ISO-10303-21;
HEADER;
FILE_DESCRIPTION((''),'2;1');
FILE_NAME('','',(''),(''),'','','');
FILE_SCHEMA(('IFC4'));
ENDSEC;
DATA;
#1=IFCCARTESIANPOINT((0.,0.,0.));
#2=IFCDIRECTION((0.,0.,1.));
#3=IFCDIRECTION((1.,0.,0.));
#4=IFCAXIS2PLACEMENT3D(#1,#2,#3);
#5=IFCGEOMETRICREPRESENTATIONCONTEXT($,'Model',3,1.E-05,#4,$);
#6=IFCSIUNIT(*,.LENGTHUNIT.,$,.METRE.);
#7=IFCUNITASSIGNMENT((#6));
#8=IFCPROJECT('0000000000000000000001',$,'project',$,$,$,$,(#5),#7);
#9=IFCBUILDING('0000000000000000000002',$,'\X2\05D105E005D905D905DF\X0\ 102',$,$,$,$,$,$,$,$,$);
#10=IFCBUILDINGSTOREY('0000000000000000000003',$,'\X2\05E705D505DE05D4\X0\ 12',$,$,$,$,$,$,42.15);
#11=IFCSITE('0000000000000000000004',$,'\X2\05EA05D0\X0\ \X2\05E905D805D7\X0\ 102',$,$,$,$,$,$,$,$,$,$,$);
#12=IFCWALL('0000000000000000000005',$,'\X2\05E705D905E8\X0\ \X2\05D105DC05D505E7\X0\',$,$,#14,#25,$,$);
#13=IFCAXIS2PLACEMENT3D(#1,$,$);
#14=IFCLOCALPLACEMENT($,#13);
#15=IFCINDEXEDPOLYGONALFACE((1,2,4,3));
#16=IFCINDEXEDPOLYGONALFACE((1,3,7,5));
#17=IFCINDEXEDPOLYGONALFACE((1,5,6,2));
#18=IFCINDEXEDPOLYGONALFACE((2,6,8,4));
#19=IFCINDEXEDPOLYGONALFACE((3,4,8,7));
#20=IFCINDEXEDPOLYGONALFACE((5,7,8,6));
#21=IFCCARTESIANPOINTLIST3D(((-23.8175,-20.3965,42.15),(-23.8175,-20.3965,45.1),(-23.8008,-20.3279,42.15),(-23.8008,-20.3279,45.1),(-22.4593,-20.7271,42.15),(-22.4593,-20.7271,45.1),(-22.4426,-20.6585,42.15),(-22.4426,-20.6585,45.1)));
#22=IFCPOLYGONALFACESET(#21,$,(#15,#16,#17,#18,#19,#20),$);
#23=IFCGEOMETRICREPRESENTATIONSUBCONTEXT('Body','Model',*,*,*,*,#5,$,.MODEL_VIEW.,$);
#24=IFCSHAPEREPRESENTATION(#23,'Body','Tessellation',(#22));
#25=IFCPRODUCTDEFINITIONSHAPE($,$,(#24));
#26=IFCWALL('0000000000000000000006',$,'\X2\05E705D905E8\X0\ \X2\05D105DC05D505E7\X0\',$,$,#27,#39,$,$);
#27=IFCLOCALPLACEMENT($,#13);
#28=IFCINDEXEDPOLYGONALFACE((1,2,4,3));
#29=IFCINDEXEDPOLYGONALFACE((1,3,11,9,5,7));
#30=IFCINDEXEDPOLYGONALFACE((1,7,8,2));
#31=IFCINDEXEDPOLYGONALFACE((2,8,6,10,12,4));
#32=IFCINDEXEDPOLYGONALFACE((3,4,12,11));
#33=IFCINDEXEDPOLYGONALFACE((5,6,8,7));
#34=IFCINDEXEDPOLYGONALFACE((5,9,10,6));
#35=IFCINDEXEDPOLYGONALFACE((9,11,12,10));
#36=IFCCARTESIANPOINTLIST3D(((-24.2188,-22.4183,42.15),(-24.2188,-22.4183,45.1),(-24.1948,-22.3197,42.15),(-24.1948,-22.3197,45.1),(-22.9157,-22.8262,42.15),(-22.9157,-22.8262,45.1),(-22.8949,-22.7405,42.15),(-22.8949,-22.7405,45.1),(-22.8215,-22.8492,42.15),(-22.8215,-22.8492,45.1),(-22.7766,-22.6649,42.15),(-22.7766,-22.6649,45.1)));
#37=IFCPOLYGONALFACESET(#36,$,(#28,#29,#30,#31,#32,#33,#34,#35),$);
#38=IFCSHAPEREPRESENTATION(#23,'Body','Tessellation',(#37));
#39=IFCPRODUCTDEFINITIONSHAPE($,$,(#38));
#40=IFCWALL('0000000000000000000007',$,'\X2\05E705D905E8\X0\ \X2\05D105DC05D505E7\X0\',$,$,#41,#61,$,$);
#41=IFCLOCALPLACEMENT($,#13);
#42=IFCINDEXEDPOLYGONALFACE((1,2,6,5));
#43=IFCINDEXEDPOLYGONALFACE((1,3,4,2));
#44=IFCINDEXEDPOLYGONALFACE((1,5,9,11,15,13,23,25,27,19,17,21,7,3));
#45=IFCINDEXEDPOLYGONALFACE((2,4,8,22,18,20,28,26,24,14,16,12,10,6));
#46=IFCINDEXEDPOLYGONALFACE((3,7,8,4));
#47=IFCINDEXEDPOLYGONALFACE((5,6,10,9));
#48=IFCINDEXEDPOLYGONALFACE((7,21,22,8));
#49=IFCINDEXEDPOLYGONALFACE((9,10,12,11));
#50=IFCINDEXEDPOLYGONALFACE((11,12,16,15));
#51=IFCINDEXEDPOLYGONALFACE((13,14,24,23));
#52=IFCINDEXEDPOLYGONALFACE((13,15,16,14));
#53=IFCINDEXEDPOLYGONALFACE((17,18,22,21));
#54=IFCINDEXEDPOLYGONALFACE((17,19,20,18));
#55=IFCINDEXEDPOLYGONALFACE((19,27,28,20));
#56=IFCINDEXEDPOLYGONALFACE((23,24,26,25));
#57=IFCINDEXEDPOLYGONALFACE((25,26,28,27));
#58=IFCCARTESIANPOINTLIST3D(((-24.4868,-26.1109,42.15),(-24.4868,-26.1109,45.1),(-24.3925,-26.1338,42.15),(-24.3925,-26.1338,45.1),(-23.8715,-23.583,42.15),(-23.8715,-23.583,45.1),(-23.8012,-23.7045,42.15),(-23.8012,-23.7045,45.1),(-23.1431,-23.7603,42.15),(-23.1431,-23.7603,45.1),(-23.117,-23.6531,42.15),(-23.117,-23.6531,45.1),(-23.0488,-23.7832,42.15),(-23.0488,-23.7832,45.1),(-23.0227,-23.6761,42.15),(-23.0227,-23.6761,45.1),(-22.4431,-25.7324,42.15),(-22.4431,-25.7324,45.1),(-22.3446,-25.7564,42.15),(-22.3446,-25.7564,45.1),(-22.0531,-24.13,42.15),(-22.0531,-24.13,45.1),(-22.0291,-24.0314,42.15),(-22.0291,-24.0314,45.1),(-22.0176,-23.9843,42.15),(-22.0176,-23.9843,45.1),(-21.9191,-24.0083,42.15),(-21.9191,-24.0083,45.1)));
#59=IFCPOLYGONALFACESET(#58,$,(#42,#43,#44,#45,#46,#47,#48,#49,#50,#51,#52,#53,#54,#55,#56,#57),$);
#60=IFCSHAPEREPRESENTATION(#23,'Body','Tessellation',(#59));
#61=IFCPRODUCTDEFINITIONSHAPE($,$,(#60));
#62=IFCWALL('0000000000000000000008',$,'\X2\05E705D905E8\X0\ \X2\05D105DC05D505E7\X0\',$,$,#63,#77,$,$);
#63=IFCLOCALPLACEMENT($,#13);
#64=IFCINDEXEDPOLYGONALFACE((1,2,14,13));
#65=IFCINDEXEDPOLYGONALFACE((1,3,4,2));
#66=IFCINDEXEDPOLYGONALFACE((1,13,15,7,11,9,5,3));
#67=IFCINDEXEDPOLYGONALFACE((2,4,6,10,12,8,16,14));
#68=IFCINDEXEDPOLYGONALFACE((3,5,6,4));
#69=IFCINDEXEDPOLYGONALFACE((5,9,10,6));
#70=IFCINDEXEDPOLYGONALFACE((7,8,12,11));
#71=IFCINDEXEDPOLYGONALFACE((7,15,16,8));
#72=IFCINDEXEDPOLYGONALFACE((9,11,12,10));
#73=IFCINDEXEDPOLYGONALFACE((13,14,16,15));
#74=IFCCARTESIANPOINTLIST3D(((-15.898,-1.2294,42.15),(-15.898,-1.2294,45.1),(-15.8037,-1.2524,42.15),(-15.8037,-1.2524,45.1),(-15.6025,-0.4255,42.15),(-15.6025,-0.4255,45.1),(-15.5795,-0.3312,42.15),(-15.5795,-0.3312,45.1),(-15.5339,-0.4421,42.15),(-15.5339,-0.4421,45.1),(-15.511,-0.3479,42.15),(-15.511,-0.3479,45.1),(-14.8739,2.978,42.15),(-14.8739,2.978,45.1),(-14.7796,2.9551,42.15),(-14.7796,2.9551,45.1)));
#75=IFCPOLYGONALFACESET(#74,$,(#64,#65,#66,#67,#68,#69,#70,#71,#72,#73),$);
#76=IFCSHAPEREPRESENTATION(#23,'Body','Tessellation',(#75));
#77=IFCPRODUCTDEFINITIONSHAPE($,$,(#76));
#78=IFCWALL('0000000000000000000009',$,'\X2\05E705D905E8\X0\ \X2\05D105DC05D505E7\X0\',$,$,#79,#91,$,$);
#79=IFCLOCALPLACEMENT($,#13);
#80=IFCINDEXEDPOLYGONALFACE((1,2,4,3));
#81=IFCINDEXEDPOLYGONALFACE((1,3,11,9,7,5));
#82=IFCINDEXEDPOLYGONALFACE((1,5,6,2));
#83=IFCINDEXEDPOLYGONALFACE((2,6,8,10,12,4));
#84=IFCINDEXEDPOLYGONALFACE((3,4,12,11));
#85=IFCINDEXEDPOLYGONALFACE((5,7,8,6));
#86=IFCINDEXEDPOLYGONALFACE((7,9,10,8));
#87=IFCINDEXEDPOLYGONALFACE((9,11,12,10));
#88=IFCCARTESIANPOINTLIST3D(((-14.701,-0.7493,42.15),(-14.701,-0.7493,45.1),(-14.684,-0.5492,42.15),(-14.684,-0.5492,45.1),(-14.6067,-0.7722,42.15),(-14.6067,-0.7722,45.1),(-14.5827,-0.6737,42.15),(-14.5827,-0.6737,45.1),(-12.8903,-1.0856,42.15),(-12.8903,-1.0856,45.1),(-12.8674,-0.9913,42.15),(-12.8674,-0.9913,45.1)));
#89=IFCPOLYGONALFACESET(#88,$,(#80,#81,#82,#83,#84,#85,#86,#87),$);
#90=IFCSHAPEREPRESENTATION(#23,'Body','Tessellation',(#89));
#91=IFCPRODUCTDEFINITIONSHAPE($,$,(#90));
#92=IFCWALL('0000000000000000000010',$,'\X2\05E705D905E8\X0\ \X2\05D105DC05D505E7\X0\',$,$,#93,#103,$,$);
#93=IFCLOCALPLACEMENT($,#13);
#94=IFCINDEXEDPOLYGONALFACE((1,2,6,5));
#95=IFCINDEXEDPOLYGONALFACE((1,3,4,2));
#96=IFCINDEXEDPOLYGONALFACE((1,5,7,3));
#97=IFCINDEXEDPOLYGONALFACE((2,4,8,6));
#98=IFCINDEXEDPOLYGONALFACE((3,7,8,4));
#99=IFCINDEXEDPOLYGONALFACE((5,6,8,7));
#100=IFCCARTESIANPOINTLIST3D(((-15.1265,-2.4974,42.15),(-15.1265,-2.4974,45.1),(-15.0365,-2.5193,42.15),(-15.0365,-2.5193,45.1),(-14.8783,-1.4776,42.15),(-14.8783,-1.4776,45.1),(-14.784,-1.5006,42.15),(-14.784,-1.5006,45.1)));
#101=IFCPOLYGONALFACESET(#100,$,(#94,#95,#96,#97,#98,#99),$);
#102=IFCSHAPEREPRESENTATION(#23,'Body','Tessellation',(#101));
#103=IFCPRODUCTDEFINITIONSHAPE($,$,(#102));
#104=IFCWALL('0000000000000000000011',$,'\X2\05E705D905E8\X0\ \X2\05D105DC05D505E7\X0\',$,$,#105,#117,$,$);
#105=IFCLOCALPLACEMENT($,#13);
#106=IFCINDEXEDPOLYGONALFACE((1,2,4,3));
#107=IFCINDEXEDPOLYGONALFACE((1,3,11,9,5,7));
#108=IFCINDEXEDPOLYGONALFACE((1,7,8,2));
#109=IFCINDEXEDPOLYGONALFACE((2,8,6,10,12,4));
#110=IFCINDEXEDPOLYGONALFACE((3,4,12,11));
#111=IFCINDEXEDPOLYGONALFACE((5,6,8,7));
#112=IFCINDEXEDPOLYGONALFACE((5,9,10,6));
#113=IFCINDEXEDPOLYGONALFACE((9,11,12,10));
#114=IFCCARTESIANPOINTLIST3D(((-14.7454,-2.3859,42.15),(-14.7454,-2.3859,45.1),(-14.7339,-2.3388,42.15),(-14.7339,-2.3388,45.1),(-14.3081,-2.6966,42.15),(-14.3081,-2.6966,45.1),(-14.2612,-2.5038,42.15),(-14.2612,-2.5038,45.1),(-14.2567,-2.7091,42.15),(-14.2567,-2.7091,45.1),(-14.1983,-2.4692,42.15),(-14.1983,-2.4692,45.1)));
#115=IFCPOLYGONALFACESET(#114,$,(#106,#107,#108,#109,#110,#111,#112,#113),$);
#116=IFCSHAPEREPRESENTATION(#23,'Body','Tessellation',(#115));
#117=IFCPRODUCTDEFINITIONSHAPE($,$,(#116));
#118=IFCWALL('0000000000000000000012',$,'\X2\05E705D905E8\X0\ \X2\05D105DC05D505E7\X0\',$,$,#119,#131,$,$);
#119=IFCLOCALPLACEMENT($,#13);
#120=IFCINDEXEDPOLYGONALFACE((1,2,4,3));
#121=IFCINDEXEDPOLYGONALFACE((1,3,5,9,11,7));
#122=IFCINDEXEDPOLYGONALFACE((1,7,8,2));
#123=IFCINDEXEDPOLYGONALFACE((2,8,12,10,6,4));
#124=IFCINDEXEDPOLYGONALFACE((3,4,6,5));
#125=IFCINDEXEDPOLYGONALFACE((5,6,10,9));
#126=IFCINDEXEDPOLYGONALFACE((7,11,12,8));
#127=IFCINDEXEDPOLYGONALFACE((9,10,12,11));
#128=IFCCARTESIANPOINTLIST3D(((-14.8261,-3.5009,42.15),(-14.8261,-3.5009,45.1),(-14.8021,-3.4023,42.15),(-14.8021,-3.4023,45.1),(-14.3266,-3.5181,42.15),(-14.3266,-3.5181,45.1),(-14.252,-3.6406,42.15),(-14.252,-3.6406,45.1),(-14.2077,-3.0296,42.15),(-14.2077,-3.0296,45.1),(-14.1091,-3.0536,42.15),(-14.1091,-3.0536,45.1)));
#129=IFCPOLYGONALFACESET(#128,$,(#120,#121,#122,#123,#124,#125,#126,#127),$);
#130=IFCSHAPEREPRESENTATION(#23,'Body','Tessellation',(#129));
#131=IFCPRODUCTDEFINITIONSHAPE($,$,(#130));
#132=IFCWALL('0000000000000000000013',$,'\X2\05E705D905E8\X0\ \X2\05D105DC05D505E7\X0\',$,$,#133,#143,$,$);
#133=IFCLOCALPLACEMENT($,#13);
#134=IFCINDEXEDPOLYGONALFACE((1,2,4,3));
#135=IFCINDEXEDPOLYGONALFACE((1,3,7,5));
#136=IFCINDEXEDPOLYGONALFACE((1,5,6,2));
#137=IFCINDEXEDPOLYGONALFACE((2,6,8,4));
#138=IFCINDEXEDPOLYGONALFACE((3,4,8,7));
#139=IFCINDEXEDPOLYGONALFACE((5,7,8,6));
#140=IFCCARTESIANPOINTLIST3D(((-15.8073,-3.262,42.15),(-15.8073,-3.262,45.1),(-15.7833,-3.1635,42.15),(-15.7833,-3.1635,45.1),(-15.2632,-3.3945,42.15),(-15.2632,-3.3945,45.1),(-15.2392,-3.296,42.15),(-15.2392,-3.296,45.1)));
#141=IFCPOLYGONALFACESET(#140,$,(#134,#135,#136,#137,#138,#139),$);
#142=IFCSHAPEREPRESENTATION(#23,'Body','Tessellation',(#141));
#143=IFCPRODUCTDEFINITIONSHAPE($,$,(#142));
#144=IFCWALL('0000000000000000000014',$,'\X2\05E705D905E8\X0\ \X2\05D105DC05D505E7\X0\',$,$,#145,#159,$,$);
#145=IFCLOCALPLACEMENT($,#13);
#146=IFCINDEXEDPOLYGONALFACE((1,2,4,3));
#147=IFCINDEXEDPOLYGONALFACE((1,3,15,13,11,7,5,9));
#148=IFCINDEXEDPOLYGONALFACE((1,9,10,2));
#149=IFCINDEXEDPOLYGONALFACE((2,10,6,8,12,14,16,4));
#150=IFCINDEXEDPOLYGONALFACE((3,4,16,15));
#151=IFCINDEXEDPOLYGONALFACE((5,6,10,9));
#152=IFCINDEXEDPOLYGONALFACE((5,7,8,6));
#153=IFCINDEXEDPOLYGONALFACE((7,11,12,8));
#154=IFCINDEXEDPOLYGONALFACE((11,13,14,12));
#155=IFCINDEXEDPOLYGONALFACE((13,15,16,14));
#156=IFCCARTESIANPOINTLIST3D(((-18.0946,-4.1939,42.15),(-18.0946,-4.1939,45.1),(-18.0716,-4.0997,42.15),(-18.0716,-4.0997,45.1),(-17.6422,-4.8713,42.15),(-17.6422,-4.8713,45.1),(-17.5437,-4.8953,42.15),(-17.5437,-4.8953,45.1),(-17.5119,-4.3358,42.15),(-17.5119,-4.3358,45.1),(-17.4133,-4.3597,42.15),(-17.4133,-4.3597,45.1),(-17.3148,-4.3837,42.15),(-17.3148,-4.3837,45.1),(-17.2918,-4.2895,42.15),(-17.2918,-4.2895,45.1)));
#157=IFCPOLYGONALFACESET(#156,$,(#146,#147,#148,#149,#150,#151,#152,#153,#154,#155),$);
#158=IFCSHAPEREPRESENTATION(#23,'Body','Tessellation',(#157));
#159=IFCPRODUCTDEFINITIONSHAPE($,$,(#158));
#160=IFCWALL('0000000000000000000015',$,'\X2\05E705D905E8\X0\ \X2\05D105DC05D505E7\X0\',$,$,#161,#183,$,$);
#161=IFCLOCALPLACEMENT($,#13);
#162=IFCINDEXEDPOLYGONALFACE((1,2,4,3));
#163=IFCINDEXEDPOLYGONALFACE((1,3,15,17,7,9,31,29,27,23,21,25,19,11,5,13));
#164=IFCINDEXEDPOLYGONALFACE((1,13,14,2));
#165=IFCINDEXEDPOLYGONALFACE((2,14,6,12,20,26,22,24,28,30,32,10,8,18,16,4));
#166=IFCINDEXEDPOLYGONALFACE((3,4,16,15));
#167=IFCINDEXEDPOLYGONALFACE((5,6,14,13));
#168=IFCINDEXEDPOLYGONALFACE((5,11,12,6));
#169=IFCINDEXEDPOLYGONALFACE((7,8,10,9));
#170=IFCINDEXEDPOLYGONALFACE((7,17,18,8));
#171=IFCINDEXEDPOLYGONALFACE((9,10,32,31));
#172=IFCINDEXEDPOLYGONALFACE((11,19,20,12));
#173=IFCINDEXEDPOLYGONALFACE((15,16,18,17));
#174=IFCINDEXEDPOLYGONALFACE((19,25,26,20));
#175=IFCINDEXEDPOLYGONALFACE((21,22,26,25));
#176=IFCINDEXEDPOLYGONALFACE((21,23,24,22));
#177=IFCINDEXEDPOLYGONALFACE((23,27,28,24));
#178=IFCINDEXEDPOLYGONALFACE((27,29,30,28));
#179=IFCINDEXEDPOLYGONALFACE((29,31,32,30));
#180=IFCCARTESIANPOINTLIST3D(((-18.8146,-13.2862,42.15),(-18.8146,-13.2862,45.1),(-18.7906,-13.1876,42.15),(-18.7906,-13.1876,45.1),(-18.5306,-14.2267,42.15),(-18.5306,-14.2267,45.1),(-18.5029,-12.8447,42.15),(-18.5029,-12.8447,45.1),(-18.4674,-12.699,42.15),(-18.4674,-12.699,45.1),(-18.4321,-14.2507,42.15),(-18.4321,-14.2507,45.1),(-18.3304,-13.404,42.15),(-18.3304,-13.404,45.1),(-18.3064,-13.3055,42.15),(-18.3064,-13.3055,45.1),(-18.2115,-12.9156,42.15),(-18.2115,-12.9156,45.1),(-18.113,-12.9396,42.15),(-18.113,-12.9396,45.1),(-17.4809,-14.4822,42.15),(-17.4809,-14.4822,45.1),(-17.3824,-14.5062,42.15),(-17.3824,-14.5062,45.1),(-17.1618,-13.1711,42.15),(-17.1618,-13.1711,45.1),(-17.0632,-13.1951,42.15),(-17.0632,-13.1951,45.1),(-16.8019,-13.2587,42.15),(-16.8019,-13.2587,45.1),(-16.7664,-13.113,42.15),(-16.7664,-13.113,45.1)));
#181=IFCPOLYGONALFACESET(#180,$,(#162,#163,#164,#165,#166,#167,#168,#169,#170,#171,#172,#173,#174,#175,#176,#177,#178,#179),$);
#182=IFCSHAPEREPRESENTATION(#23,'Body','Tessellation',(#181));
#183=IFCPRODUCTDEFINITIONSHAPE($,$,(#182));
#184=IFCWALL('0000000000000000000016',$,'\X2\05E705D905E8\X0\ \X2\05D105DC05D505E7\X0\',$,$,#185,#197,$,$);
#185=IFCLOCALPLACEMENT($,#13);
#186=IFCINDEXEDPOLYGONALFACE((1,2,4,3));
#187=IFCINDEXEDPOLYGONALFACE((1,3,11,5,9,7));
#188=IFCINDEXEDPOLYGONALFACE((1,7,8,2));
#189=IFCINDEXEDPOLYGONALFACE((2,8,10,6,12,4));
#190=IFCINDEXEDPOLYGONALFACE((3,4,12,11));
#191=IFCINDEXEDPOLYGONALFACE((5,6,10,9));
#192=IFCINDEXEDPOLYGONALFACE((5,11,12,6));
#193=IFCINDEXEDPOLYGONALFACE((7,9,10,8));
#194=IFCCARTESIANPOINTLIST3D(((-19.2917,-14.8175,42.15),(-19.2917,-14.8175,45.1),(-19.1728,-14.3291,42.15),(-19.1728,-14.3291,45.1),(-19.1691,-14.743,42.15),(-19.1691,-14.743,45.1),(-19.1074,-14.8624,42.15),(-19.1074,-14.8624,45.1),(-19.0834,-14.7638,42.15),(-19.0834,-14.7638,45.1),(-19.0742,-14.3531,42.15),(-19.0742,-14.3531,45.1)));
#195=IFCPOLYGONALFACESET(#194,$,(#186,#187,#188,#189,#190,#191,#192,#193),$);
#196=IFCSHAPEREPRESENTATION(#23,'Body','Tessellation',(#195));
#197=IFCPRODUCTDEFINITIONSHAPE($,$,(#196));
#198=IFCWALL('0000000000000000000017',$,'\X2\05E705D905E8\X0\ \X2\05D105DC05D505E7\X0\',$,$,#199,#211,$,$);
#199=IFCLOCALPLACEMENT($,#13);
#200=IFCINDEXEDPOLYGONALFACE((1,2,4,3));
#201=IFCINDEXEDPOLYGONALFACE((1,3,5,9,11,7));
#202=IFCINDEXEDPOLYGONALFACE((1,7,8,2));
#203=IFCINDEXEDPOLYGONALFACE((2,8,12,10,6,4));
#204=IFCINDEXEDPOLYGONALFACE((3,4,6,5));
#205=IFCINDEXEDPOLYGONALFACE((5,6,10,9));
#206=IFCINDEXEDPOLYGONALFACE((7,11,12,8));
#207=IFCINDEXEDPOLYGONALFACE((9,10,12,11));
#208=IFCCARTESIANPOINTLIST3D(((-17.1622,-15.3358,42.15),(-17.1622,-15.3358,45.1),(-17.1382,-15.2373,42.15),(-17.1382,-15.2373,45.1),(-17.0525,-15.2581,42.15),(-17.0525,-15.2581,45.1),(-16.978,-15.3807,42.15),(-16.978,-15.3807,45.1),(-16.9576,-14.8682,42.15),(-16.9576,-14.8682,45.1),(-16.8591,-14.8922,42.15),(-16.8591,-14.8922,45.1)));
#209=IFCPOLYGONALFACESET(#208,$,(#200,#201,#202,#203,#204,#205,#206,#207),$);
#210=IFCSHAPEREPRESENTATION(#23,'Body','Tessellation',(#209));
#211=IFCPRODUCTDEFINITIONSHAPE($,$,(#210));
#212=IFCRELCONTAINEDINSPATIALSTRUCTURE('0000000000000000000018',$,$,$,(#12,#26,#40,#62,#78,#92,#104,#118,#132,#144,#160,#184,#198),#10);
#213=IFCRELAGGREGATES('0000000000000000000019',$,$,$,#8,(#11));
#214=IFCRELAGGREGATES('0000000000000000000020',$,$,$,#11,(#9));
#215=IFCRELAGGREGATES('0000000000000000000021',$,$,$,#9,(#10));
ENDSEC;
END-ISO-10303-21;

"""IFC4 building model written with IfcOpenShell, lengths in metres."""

from ifc_helpers import new_model, si_unit, frame, origin_with_axes, context, subcontext, project, spatial, polyline, outline, extrude, element, save


model = new_model("IFC4")

# Units and contexts
model_context = context("Model", 3, precision=1e-05, world=origin_with_axes())
body_context = subcontext(model_context, "Body", "Model", "MODEL_VIEW")
ifc_project = project(units=[si_unit("LENGTHUNIT", "METRE")], contexts=[model_context])

# Site, building, storey
site = spatial("IfcSite", under=ifc_project, Name="תא שטח 102")
building = spatial("IfcBuilding", under=site, Name="בניין 102")
storey = spatial("IfcBuildingStorey", under=building, Name="קומה 12", Elevation=42.15)

# Walls
element("IfcWall", 1, inside=storey, Name="קיר בלוק", context=body_context, shape_type="SweptSolid", body=[
    extrude(outline(polyline([(-22.4426, -20.6585), (-23.8008, -20.3279), (-23.8175, -20.3965), (-22.4593, -20.7271), (-22.4426, -20.6585)])), frame((0.0, 0.0, 42.15)), (0.0, 0.0, 1.0), 2.95),
])
element("IfcWall", 2, inside=storey, Name="קיר בלוק", context=body_context, shape_type="SweptSolid", body=[
    extrude(outline(polyline([(-24.2188, -22.4183), (-22.8949, -22.7405), (-22.9157, -22.8262), (-22.8215, -22.8492), (-22.7766, -22.6649), (-24.1948, -22.3197), (-24.2188, -22.4183)])), frame((0.0, 0.0, 42.15)), (0.0, 0.0, 1.0), 2.95),
])
element("IfcWall", 3, inside=storey, Name="קיר בלוק", context=body_context, shape_type="SweptSolid", body=[
    extrude(outline(polyline([(-23.8012, -23.7045), (-22.0531, -24.13), (-22.4431, -25.7324), (-22.3446, -25.7564), (-21.9191, -24.0083), (-22.0176, -23.9843), (-22.0291, -24.0314), (-23.0488, -23.7832), (-23.0227, -23.6761), (-23.117, -23.6531), (-23.1431, -23.7603), (-23.8715, -23.583), (-24.4868, -26.1109), (-24.3925, -26.1338), (-23.8012, -23.7045)])), frame((0.0, 0.0, 42.15)), (0.0, 0.0, 1.0), 2.95),
])
element("IfcWall", 4, inside=storey, Name="קיר בלוק", context=body_context, shape_type="SweptSolid", body=[
    extrude(outline(polyline([(-14.8739, 2.978), (-15.898, -1.2294), (-15.8037, -1.2524), (-15.6025, -0.4255), (-15.5339, -0.4421), (-15.511, -0.3479), (-15.5795, -0.3312), (-14.7796, 2.9551), (-14.8739, 2.978)])), frame((0.0, 0.0, 42.15)), (0.0, 0.0, 1.0), 2.95),
])
element("IfcWall", 5, inside=storey, Name="קיר בלוק", context=body_context, shape_type="SweptSolid", body=[
    extrude(outline(polyline([(-14.701, -0.7493), (-14.6067, -0.7722), (-14.5827, -0.6737), (-12.8903, -1.0856), (-12.8674, -0.9913), (-14.684, -0.5492), (-14.701, -0.7493)])), frame((0.0, 0.0, 42.15)), (0.0, 0.0, 1.0), 2.95),
])
element("IfcWall", 6, inside=storey, Name="קיר בלוק", context=body_context, shape_type="SweptSolid", body=[
    extrude(outline(polyline([(-15.1265, -2.4974), (-15.0365, -2.5193), (-14.784, -1.5006), (-14.8783, -1.4776), (-15.1265, -2.4974)])), frame((0.0, 0.0, 42.15)), (0.0, 0.0, 1.0), 2.95),
])
element("IfcWall", 7, inside=storey, Name="קיר בלוק", context=body_context, shape_type="SweptSolid", body=[
    extrude(outline(polyline([(-14.7454, -2.3859), (-14.2612, -2.5038), (-14.3081, -2.6966), (-14.2567, -2.7091), (-14.1983, -2.4692), (-14.7339, -2.3388), (-14.7454, -2.3859)])), frame((0.0, 0.0, 42.15)), (0.0, 0.0, 1.0), 2.95),
])
element("IfcWall", 8, inside=storey, Name="קיר בלוק", context=body_context, shape_type="SweptSolid", body=[
    extrude(outline(polyline([(-14.8021, -3.4023), (-14.8261, -3.5009), (-14.252, -3.6406), (-14.1091, -3.0536), (-14.2077, -3.0296), (-14.3266, -3.5181), (-14.8021, -3.4023)])), frame((0.0, 0.0, 42.15)), (0.0, 0.0, 1.0), 2.95),
])
element("IfcWall", 9, inside=storey, Name="קיר בלוק", context=body_context, shape_type="SweptSolid", body=[
    extrude(outline(polyline([(-15.7833, -3.1635), (-15.8073, -3.262), (-15.2632, -3.3945), (-15.2392, -3.296), (-15.7833, -3.1635)])), frame((0.0, 0.0, 42.15)), (0.0, 0.0, 1.0), 2.95),
])
element("IfcWall", 10, inside=storey, Name="קיר בלוק", context=body_context, shape_type="SweptSolid", body=[
    extrude(outline(polyline([(-17.4133, -4.3597), (-17.3148, -4.3837), (-17.2918, -4.2895), (-18.0716, -4.0997), (-18.0946, -4.1939), (-17.5119, -4.3358), (-17.6422, -4.8713), (-17.5437, -4.8953), (-17.4133, -4.3597)])), frame((0.0, 0.0, 42.15)), (0.0, 0.0, 1.0), 2.95),
])
element("IfcWall", 11, inside=storey, Name="קיר בלוק", context=body_context, shape_type="SweptSolid", body=[
    extrude(outline(polyline([(-18.7906, -13.1876), (-18.8146, -13.2862), (-18.3304, -13.404), (-18.5306, -14.2267), (-18.4321, -14.2507), (-18.113, -12.9396), (-17.1618, -13.1711), (-17.4809, -14.4822), (-17.3824, -14.5062), (-17.0632, -13.1951), (-16.8019, -13.2587), (-16.7664, -13.113), (-18.4674, -12.699), (-18.5029, -12.8447), (-18.2115, -12.9156), (-18.3064, -13.3055), (-18.7906, -13.1876)])), frame((0.0, 0.0, 42.15)), (0.0, 0.0, 1.0), 2.95),
])
element("IfcWall", 12, inside=storey, Name="קיר בלוק", context=body_context, shape_type="SweptSolid", body=[
    extrude(outline(polyline([(-19.0834, -14.7638), (-19.1691, -14.743), (-19.0742, -14.3531), (-19.1728, -14.3291), (-19.2917, -14.8175), (-19.1074, -14.8624), (-19.0834, -14.7638)])), frame((0.0, 0.0, 42.15)), (0.0, 0.0, 1.0), 2.95),
])
element("IfcWall", 13, inside=storey, Name="קיר בלוק", context=body_context, shape_type="SweptSolid", body=[
    extrude(outline(polyline([(-16.978, -15.3807), (-16.8591, -14.8922), (-16.9576, -14.8682), (-17.0525, -15.2581), (-17.1382, -15.2373), (-17.1622, -15.3358), (-16.978, -15.3807)])), frame((0.0, 0.0, 42.15)), (0.0, 0.0, 1.0), 2.95),
])

save(model, "model.ifc")
